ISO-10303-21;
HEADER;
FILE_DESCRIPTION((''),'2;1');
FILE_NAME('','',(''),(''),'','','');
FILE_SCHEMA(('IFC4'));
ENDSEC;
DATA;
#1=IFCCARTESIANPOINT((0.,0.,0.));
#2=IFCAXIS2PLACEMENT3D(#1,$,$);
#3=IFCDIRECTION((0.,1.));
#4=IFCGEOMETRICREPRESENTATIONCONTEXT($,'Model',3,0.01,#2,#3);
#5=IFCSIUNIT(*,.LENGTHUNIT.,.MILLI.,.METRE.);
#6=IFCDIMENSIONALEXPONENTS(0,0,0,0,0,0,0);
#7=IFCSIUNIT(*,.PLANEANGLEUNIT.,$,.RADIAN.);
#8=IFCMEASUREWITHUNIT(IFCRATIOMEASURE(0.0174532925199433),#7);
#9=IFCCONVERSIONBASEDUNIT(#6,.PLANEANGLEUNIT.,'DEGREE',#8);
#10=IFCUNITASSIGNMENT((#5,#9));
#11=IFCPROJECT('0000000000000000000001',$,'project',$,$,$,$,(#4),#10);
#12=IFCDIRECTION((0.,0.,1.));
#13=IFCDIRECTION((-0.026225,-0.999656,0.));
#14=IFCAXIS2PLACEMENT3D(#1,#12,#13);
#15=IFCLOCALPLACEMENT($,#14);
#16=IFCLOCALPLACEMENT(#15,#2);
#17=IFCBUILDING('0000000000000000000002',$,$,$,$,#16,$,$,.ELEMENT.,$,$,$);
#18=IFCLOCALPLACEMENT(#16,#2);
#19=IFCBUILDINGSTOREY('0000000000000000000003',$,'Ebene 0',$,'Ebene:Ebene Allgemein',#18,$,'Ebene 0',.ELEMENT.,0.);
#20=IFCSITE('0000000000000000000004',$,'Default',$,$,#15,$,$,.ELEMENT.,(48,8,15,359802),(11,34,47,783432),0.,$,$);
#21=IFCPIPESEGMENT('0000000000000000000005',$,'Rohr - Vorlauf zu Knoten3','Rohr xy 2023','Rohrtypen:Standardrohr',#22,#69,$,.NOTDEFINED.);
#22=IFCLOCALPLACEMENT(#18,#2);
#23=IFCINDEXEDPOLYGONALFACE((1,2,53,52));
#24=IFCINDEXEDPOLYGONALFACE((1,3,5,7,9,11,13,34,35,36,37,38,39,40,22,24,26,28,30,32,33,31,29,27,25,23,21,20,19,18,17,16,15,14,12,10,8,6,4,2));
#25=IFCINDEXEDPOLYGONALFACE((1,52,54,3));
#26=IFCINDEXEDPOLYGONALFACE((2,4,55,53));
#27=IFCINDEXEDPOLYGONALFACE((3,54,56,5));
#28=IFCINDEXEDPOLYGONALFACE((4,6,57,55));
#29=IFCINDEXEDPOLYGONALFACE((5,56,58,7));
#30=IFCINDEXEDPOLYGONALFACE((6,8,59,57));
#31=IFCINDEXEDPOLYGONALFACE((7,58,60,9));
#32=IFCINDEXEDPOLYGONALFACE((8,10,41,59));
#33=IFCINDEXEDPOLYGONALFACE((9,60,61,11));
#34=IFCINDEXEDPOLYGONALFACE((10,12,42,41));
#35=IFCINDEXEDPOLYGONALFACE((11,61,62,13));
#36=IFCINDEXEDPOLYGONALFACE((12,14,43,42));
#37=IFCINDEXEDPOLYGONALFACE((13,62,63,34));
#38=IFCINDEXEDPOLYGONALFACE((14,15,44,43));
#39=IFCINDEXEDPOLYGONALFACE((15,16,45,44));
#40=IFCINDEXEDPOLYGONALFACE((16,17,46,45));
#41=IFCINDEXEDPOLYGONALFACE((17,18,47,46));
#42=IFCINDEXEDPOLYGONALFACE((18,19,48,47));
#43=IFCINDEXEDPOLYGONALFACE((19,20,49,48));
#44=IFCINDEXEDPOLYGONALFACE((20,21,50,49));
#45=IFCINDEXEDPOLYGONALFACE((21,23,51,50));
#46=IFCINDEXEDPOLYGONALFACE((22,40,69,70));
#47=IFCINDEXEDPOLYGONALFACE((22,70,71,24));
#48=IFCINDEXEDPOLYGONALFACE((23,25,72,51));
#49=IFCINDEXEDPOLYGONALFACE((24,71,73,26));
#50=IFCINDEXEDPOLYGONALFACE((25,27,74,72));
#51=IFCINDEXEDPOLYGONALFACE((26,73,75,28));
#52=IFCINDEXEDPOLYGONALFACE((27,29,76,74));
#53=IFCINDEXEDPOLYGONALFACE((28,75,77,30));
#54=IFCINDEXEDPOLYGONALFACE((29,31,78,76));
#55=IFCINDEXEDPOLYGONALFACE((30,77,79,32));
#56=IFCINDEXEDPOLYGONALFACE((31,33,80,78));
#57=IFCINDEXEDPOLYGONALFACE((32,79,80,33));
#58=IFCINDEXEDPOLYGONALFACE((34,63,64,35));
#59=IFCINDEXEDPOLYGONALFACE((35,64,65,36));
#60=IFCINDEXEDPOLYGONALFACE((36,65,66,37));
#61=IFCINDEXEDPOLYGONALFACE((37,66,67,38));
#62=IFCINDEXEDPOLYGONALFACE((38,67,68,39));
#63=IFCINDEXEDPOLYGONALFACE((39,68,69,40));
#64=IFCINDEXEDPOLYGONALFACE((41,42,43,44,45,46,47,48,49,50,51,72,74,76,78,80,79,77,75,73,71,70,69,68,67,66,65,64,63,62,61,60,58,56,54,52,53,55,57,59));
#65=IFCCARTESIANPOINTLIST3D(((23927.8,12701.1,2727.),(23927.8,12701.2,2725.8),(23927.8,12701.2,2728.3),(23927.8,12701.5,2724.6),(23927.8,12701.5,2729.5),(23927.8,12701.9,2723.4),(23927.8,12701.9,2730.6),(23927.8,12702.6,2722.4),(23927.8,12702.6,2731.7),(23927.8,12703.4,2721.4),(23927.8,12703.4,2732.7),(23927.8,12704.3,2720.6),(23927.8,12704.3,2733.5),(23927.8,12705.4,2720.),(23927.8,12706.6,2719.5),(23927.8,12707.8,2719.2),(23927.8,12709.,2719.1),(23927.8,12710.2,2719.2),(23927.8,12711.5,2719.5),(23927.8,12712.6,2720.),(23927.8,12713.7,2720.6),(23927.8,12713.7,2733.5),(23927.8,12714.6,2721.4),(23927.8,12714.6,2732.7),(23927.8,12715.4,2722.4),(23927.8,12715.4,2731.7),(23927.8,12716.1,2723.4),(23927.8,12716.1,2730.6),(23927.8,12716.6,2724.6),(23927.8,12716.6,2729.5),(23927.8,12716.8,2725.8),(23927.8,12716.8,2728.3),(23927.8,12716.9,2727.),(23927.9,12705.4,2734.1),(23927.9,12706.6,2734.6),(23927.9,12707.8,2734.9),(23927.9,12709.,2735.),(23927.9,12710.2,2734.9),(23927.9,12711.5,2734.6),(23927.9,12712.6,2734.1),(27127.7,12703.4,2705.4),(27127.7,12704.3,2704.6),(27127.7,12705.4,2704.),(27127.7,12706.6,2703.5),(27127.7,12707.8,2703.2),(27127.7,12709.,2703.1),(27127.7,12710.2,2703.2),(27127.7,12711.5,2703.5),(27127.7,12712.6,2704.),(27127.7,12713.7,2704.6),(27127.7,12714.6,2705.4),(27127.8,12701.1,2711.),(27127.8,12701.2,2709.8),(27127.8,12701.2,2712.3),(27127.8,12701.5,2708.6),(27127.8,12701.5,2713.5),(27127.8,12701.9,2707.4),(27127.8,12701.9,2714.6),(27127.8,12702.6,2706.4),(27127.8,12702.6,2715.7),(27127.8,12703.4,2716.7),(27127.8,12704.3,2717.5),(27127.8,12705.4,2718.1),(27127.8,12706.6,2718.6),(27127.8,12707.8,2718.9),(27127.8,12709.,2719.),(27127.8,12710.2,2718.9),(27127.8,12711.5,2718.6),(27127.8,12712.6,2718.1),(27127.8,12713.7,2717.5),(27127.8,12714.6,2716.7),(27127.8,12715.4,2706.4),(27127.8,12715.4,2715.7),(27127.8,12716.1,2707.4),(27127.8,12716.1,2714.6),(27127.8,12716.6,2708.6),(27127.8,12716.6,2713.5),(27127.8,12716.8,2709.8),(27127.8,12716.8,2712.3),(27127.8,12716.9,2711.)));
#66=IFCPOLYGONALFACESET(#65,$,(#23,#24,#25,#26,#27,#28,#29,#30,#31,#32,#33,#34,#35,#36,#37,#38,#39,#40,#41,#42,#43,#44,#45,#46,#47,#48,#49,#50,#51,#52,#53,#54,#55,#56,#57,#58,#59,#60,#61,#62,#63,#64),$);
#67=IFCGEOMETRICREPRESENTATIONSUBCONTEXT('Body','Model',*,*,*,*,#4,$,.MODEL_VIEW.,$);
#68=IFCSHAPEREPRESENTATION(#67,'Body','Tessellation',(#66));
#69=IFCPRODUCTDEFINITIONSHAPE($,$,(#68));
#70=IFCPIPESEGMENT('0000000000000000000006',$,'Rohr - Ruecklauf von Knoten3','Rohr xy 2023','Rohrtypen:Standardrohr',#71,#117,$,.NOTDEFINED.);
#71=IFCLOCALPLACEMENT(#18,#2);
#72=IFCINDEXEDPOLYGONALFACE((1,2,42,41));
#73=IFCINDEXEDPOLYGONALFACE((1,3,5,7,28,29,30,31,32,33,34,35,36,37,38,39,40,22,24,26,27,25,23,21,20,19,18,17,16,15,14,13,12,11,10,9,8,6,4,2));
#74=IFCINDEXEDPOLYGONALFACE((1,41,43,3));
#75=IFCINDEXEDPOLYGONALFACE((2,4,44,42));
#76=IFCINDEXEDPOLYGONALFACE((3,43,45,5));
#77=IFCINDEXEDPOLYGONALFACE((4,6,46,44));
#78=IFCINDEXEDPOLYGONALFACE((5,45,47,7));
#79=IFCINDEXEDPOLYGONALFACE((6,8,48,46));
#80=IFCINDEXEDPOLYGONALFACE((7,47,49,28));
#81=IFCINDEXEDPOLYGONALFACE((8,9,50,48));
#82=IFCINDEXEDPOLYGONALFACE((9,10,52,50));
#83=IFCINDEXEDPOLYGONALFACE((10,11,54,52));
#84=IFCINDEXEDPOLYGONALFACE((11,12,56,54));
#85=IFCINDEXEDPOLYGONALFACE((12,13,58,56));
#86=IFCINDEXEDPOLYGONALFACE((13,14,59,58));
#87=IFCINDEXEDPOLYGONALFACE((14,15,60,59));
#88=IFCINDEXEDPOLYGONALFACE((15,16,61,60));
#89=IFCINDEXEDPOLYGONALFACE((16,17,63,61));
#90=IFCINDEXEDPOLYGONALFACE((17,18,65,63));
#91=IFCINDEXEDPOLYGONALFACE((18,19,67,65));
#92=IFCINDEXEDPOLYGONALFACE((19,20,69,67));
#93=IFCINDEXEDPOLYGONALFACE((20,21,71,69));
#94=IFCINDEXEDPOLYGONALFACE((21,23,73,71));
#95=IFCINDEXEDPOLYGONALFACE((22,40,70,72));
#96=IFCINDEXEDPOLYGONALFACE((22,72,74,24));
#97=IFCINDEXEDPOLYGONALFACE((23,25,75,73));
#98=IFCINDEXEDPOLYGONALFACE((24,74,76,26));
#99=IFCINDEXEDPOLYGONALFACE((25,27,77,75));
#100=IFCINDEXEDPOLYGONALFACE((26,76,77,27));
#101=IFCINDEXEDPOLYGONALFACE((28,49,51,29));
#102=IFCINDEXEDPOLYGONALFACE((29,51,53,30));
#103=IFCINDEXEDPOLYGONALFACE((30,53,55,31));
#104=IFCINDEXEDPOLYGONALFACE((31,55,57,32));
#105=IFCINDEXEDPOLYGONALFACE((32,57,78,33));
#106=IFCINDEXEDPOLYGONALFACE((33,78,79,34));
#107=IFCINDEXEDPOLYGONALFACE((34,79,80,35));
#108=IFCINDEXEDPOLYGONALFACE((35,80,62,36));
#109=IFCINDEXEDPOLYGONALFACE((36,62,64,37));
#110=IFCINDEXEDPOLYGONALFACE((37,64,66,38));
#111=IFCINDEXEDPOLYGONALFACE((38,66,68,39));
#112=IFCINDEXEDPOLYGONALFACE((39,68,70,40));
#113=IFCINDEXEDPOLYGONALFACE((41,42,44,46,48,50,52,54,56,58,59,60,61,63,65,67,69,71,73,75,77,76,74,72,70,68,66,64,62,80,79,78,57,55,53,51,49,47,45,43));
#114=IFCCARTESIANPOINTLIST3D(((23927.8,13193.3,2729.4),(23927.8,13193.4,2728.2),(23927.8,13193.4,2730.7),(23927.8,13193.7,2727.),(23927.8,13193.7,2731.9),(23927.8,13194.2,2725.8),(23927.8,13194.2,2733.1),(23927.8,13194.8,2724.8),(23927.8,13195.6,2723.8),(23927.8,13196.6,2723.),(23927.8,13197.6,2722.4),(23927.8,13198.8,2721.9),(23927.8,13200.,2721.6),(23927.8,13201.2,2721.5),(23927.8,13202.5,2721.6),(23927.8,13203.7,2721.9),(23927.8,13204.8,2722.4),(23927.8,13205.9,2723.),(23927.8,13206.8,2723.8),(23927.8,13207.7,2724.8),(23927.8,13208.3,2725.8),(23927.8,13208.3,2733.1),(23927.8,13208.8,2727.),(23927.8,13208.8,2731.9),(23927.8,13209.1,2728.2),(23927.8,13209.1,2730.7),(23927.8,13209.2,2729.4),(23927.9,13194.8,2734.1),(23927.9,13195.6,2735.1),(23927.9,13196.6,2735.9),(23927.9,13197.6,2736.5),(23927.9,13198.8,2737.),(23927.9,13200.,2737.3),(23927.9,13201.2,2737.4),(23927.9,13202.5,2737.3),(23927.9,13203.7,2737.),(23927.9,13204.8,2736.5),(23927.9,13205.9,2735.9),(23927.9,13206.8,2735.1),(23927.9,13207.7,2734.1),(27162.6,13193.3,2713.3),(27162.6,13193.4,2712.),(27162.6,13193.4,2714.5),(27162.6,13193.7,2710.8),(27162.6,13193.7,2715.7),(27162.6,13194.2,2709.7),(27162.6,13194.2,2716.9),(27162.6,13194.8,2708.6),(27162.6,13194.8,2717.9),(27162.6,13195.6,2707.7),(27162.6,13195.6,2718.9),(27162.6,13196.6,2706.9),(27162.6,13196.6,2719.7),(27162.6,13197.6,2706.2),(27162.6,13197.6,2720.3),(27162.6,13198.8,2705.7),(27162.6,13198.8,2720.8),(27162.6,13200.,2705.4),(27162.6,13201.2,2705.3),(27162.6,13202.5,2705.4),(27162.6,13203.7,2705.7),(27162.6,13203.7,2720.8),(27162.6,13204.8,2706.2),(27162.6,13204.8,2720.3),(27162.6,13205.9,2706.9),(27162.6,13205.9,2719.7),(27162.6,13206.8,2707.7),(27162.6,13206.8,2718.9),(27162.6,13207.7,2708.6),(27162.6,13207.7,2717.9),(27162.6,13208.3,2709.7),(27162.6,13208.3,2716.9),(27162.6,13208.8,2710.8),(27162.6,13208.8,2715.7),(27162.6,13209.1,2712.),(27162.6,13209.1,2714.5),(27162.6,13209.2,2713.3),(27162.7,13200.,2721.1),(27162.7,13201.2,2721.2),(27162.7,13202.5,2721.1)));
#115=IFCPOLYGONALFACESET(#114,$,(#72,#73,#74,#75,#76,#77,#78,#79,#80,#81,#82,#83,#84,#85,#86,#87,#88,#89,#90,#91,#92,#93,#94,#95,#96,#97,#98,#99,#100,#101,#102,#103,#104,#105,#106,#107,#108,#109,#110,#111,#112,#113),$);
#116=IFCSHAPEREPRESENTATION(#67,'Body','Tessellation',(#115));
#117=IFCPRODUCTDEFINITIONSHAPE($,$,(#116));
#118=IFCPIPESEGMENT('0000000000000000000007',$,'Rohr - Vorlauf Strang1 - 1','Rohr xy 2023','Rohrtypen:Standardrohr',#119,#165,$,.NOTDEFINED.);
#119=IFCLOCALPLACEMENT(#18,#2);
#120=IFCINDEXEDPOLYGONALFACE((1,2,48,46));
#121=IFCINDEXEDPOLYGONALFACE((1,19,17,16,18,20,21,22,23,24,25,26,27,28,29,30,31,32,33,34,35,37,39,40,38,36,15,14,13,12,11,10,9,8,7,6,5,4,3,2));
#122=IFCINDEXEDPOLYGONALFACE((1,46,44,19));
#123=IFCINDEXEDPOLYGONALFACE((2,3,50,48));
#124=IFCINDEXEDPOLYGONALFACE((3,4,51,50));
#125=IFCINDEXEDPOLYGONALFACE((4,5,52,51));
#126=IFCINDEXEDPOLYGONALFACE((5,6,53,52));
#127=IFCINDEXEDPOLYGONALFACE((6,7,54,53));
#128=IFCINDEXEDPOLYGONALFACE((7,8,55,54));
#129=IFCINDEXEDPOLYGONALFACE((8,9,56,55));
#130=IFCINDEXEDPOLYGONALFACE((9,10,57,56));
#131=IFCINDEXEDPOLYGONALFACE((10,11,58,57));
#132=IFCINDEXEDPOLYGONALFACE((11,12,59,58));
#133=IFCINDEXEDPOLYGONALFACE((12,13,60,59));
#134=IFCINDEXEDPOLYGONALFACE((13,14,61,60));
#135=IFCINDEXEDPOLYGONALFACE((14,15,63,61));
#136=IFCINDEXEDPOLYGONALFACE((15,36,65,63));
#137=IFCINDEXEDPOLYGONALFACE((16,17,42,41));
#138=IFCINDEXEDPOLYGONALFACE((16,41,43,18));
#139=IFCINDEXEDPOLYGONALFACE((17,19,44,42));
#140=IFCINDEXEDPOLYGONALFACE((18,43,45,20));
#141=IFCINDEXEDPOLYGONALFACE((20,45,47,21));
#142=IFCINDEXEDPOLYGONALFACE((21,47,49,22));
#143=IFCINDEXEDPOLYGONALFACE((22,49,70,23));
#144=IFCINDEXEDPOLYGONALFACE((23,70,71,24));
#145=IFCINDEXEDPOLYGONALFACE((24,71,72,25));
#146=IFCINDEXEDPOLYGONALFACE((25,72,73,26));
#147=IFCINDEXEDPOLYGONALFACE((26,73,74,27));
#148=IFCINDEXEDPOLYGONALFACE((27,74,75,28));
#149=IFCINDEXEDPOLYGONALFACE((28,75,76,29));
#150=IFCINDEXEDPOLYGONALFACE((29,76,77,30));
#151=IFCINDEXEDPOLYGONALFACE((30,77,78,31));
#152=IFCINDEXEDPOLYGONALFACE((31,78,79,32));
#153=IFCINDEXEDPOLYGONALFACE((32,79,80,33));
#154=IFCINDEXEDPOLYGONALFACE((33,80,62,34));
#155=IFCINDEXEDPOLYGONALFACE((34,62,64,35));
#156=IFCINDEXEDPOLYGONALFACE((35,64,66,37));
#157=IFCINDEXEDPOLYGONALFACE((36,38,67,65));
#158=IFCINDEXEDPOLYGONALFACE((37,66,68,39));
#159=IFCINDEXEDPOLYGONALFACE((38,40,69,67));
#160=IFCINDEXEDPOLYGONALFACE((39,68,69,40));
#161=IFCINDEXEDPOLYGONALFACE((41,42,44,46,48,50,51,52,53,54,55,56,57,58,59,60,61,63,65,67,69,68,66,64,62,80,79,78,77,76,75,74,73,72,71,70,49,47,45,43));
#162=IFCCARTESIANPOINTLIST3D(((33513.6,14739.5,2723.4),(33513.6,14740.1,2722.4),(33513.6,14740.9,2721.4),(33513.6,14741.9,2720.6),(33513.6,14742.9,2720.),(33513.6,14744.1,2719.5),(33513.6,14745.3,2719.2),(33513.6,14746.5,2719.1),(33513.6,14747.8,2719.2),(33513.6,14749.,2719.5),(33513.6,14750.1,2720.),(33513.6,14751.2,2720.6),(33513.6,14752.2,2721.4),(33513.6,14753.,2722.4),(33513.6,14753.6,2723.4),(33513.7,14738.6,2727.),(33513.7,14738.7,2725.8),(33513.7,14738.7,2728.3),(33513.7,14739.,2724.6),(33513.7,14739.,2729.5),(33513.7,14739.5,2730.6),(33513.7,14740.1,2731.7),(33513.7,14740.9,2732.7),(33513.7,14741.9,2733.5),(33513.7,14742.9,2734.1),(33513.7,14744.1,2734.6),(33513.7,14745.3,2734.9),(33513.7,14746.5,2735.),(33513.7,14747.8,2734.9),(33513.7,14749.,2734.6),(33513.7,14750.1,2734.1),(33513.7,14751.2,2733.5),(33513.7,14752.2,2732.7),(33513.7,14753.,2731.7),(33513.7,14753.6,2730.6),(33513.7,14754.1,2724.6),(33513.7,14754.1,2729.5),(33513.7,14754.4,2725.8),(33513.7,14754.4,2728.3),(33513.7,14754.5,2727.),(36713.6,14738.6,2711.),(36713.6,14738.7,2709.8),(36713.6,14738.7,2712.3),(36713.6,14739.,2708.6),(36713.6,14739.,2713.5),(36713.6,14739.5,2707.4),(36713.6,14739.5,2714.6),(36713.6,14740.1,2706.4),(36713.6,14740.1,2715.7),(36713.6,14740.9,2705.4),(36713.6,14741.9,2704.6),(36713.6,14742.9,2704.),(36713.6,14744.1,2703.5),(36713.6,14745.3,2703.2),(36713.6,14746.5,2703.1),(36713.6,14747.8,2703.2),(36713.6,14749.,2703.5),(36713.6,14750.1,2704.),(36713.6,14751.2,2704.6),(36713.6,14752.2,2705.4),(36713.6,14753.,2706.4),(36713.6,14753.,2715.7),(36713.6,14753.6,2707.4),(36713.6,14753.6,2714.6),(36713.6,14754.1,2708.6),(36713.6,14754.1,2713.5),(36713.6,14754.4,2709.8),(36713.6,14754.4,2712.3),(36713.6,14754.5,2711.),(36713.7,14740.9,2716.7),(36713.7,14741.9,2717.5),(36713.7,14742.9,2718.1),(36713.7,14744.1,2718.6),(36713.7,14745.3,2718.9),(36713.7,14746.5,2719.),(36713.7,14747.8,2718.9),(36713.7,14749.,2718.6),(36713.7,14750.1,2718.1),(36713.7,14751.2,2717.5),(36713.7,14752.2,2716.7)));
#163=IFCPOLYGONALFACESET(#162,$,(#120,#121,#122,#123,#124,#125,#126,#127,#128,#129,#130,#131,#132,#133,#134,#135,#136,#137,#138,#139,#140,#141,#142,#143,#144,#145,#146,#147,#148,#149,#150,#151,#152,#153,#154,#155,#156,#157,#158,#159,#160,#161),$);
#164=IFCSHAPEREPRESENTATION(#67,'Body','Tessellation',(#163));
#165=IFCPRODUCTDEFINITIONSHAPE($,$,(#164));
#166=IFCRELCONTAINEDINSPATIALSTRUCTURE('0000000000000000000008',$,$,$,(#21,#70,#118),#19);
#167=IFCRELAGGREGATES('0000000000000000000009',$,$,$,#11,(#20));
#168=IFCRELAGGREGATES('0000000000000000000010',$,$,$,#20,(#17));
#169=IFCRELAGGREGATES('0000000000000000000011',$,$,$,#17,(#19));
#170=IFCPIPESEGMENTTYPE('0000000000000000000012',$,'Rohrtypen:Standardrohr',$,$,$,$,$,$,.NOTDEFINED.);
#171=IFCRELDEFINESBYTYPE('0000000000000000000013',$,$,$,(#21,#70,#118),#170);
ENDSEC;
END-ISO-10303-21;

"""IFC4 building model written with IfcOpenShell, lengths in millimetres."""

from ifc_helpers import new_model, entity, si_unit, converted_unit, direction, frame, origin, place, context, subcontext, project, spatial, indexed_curve, outline, extrude, type_object, element, save


model = new_model("IFC4")

# Units and contexts
model_context = context("Model", 3, precision=0.01, world=origin(), true_north=direction((0.0, 1.0)))
body_context = subcontext(model_context, "Body", "Model", "MODEL_VIEW")
ifc_project = project(units=[si_unit("LENGTHUNIT", "METRE", prefix="MILLI"), converted_unit("PLANEANGLEUNIT", "DEGREE", entity("IfcRatioMeasure", 0.0174532925199433), si_unit("PLANEANGLEUNIT", "RADIAN"), dimensions=[0, 0, 0, 0, 0, 0, 0])], contexts=[model_context])

# Site, building, storey
site_placement = place(None, frame((0.0, 0.0, 0.0), z_axis=(0.0, 0.0, 1.0), x_axis=(-0.026225, -0.999656, 0.0)))
site = spatial("IfcSite", under=ifc_project, at=site_placement, Name="Default", CompositionType="ELEMENT", RefLatitude=(48, 8, 15, 359802), RefLongitude=(11, 34, 47, 783432), RefElevation=0.0)
building_placement = place(site_placement, origin())
building = spatial("IfcBuilding", under=site, at=building_placement, CompositionType="ELEMENT")
storey_placement = place(building_placement, origin())
storey = spatial("IfcBuildingStorey", under=building, at=storey_placement, Name="Ebene 0", ObjectType="Ebene:Ebene Allgemein", LongName="Ebene 0", CompositionType="ELEMENT", Elevation=0.0)

# Pipe segments
pipe_segment_type = type_object("IfcPipeSegmentType", Name="Rohrtypen:Standardrohr", PredefinedType="NOTDEFINED")
pipe_segment_1_placement = place(storey_placement, origin())
element("IfcPipeSegment", 1, at=pipe_segment_1_placement, inside=storey, type_object=pipe_segment_type, Name="Rohr - Vorlauf zu Knoten3", Description="Rohr xy 2023", ObjectType="Rohrtypen:Standardrohr", PredefinedType="NOTDEFINED", context=body_context, shape_type="SweptSolid", body=[
    extrude(outline(indexed_curve([(7.9, 0.0), (7.8, 1.2), (7.6, 2.5), (7.1, 3.6), (6.4, 4.7), (5.6, 5.6), (4.7, 6.4), (3.6, 7.1), (2.5, 7.6), (1.2, 7.8), (0.0, 7.9), (-1.2, 7.8), (-2.5, 7.6), (-3.6, 7.1), (-4.7, 6.4), (-5.6, 5.6), (-6.4, 4.7), (-7.1, 3.6), (-7.6, 2.5), (-7.8, 1.2), (-7.9, 0.0), (-7.8, -1.2), (-7.6, -2.5), (-7.1, -3.6), (-6.4, -4.7), (-5.6, -5.6), (-4.7, -6.4), (-3.6, -7.1), (-2.5, -7.6), (-1.2, -7.8), (0.0, -7.9), (1.2, -7.8), (2.5, -7.6), (3.6, -7.1), (4.7, -6.4), (5.6, -5.6), (6.4, -4.7), (7.1, -3.6), (7.6, -2.5), (7.8, -1.2), (7.9, 0.0)], self_intersect=False)), frame((27127.8, 12709.0, 2711.0), z_axis=(-0.999988, 0.0, 0.005), x_axis=(0.0, 1.0, 0.0)), (0.0, 0.0, 1.0), 3200.0),
])
pipe_segment_2_placement = place(storey_placement, origin())
element("IfcPipeSegment", 2, at=pipe_segment_2_placement, inside=storey, type_object=pipe_segment_type, Name="Rohr - Ruecklauf von Knoten3", Description="Rohr xy 2023", ObjectType="Rohrtypen:Standardrohr", PredefinedType="NOTDEFINED", context=body_context, shape_type="SweptSolid", body=[
    extrude(outline(indexed_curve([(7.9, 0.0), (7.8, 1.2), (7.6, 2.5), (7.1, 3.6), (6.4, 4.7), (5.6, 5.6), (4.7, 6.4), (3.6, 7.1), (2.5, 7.6), (1.2, 7.8), (0.0, 7.9), (-1.2, 7.8), (-2.5, 7.6), (-3.6, 7.1), (-4.7, 6.4), (-5.6, 5.6), (-6.4, 4.7), (-7.1, 3.6), (-7.6, 2.5), (-7.8, 1.2), (-7.9, 0.0), (-7.8, -1.2), (-7.6, -2.5), (-7.1, -3.6), (-6.4, -4.7), (-5.6, -5.6), (-4.7, -6.4), (-3.6, -7.1), (-2.5, -7.6), (-1.2, -7.8), (0.0, -7.9), (1.2, -7.8), (2.5, -7.6), (3.6, -7.1), (4.7, -6.4), (5.6, -5.6), (6.4, -4.7), (7.1, -3.6), (7.6, -2.5), (7.8, -1.2), (7.9, 0.0)], self_intersect=False)), frame((27162.6, 13201.2, 2713.3), z_axis=(-0.999988, 0.0, 0.005), x_axis=(0.0, 1.0, 0.0)), (0.0, 0.0, 1.0), 3234.8),
])
pipe_segment_3_placement = place(storey_placement, origin())
element("IfcPipeSegment", 3, at=pipe_segment_3_placement, inside=storey, type_object=pipe_segment_type, Name="Rohr - Vorlauf Strang1 - 1", Description="Rohr xy 2023", ObjectType="Rohrtypen:Standardrohr", PredefinedType="NOTDEFINED", context=body_context, shape_type="SweptSolid", body=[
    extrude(outline(indexed_curve([(7.9, 0.0), (7.8, 1.2), (7.6, 2.5), (7.1, 3.6), (6.4, 4.7), (5.6, 5.6), (4.7, 6.4), (3.6, 7.1), (2.5, 7.6), (1.2, 7.8), (0.0, 7.9), (-1.2, 7.8), (-2.5, 7.6), (-3.6, 7.1), (-4.7, 6.4), (-5.6, 5.6), (-6.4, 4.7), (-7.1, 3.6), (-7.6, 2.5), (-7.8, 1.2), (-7.9, 0.0), (-7.8, -1.2), (-7.6, -2.5), (-7.1, -3.6), (-6.4, -4.7), (-5.6, -5.6), (-4.7, -6.4), (-3.6, -7.1), (-2.5, -7.6), (-1.2, -7.8), (0.0, -7.9), (1.2, -7.8), (2.5, -7.6), (3.6, -7.1), (4.7, -6.4), (5.6, -5.6), (6.4, -4.7), (7.1, -3.6), (7.6, -2.5), (7.8, -1.2), (7.9, 0.0)], self_intersect=False)), frame((36713.6, 14746.5, 2711.0), z_axis=(-0.999988, 0.0, 0.005), x_axis=(0.0, 1.0, 0.0)), (0.0, 0.0, 1.0), 3200.0),
])

save(model, "model.ifc")
